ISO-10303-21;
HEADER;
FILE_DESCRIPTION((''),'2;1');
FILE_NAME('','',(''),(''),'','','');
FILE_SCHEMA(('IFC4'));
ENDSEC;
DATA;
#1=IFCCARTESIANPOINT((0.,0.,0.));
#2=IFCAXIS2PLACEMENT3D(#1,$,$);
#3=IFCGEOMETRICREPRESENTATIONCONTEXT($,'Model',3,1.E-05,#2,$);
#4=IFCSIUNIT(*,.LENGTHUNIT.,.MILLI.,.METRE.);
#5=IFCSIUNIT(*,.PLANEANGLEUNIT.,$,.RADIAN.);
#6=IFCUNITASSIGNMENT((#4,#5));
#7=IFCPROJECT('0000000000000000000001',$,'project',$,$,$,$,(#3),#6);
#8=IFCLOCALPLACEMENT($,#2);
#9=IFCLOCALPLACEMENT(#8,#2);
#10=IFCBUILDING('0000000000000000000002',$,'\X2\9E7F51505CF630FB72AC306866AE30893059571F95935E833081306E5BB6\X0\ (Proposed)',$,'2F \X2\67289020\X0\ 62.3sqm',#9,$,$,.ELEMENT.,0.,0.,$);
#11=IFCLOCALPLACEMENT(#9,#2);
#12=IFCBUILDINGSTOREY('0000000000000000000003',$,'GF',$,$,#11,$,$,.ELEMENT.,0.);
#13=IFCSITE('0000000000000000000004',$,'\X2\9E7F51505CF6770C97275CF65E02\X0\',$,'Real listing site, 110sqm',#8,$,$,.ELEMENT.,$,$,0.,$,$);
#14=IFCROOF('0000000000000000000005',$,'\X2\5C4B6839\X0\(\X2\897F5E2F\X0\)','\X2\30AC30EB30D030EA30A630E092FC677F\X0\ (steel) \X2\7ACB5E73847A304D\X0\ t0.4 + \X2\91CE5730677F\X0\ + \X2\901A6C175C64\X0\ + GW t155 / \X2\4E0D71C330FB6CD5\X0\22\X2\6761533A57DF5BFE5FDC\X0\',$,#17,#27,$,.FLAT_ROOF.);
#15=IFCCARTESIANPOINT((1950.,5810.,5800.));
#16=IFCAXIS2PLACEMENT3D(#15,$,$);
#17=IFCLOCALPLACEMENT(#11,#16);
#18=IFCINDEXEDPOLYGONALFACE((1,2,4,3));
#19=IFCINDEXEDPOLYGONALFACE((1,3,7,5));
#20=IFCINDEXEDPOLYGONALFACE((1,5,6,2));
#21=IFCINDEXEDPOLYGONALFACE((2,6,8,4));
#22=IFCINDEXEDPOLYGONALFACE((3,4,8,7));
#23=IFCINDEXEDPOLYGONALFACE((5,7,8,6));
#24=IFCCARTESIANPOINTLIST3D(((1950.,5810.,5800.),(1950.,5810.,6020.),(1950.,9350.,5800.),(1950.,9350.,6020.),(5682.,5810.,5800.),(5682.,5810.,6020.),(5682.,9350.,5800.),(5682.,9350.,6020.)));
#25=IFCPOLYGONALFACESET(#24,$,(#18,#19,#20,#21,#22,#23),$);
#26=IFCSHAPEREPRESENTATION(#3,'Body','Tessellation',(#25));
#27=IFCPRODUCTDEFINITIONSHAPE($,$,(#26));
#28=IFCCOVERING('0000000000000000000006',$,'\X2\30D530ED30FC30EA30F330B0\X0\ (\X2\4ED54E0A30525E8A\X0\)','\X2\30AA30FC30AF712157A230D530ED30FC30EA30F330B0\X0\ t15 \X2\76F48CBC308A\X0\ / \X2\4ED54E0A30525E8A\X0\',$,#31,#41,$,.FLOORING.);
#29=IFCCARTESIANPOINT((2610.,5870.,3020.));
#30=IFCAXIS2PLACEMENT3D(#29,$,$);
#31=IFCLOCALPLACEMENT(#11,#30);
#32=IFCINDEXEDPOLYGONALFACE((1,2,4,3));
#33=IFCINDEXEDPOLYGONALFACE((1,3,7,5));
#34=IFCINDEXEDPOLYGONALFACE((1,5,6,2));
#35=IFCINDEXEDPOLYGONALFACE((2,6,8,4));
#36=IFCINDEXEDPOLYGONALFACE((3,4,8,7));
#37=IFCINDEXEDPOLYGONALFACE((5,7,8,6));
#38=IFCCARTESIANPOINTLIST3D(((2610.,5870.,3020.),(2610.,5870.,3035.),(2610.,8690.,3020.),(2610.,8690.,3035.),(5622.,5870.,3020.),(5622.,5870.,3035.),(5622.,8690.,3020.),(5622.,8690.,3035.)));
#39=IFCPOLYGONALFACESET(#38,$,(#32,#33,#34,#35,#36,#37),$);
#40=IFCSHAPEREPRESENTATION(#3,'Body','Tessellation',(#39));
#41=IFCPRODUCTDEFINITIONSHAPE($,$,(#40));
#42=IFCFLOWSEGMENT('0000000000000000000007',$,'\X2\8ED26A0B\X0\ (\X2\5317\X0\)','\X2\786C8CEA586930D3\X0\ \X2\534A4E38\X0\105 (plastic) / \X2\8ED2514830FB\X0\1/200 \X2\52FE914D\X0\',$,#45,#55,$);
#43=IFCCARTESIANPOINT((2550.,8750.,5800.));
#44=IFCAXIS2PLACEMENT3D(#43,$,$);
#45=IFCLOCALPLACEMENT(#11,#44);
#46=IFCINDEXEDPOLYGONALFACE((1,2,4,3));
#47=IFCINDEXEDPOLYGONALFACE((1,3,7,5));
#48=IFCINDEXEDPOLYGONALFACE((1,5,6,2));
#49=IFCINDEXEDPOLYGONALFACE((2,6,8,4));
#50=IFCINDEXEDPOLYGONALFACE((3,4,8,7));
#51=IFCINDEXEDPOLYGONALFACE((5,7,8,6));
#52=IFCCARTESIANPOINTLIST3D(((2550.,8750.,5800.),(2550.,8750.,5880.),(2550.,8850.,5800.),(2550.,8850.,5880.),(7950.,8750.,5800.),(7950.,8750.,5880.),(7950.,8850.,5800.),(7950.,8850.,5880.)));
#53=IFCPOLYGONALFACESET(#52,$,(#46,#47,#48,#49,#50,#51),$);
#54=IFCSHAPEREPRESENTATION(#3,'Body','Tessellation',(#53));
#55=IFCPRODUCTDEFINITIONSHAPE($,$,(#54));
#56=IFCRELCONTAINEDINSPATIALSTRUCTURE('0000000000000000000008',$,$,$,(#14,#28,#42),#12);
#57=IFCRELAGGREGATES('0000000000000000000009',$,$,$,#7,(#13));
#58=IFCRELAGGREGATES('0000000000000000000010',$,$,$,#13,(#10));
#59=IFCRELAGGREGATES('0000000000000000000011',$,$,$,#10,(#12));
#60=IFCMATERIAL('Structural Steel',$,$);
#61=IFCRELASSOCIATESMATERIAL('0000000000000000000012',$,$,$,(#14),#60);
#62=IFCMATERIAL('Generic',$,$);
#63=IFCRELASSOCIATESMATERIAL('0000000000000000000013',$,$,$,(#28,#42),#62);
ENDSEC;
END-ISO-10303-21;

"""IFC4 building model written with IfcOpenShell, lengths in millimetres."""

from ifc_helpers import new_model, si_unit, frame, frame_2d, origin, place, context, project, spatial, rectangle, extrude, material, element, save


model = new_model("IFC4")

# Units and contexts
model_context = context("Model", 3, precision=1e-05, world=origin())
ifc_project = project(units=[si_unit("LENGTHUNIT", "METRE", prefix="MILLI"), si_unit("PLANEANGLEUNIT", "RADIAN")], contexts=[model_context])

# Site, building, storey
site_placement = place(None, origin())
site = spatial("IfcSite", under=ifc_project, at=site_placement, Name="鹿児島県霧島市", ObjectType="Real listing site, 110sqm", CompositionType="ELEMENT", RefElevation=0.0)
building_placement = place(site_placement, origin())
building = spatial("IfcBuilding", under=site, at=building_placement, Name="鹿児島・犬と暮らす土間広めの家 (Proposed)", ObjectType="2F 木造 62.3sqm", CompositionType="ELEMENT", ElevationOfRefHeight=0.0, ElevationOfTerrain=0.0)
storey_placement = place(building_placement, origin())
storey = spatial("IfcBuildingStorey", under=building, at=storey_placement, Name="GF", CompositionType="ELEMENT", Elevation=0.0)

# Roof
ifc_material_1 = material(Name="Structural Steel")
for number, where, name in (
    (1, (1950.0, 5810.0, 5800.0), "屋根(西帯)"),
):
    element("IfcRoof", number, at=place(storey_placement, frame(where)), inside=storey, material=ifc_material_1, Name=name, Description="ガルバリウム鋼板 (steel) 立平葺き t0.4 + 野地板 + 通気層 + GW t155 / 不燃・法22条区域対応", PredefinedType="FLAT_ROOF", context=model_context, shape_type="SweptSolid", body=[
        extrude(rectangle(XDim=3732.0, YDim=3540.0, at=frame_2d((1866.0, 1770.0))), frame((1950.0, 5810.0, 5800.0)), (0.0, 0.0, 1.0), 220.0),
    ])

# Covering
ifc_material_2 = material(Name="Generic")
covering_placement = place(storey_placement, frame((2610.0, 5870.0, 3020.0)))
element("IfcCovering", 2, at=covering_placement, inside=storey, material=ifc_material_2, Name="フローリング (仕上げ床)", Description="オーク無垢フローリング t15 直貼り / 仕上げ床", PredefinedType="FLOORING", context=model_context, shape_type="SweptSolid", body=[
    extrude(rectangle(XDim=3012.0, YDim=2820.0, at=frame_2d((1506.0, 1410.0))), frame((2610.0, 5870.0, 3020.0)), (0.0, 0.0, 1.0), 15.0),
])

# Flow segment
flow_segment_placement = place(storey_placement, frame((2550.0, 8750.0, 5800.0)))
element("IfcFlowSegment", 3, at=flow_segment_placement, inside=storey, material=ifc_material_2, Name="軒樋 (北)", Description="硬質塩ビ 半丸105 (plastic) / 軒先・1/200 勾配", context=model_context, shape_type="SweptSolid", body=[
    extrude(rectangle(XDim=5400.0, YDim=100.0, at=frame_2d((2700.0, 50.0))), frame((2550.0, 8750.0, 5800.0)), (0.0, 0.0, 1.0), 80.0),
])

save(model, "model.ifc")
